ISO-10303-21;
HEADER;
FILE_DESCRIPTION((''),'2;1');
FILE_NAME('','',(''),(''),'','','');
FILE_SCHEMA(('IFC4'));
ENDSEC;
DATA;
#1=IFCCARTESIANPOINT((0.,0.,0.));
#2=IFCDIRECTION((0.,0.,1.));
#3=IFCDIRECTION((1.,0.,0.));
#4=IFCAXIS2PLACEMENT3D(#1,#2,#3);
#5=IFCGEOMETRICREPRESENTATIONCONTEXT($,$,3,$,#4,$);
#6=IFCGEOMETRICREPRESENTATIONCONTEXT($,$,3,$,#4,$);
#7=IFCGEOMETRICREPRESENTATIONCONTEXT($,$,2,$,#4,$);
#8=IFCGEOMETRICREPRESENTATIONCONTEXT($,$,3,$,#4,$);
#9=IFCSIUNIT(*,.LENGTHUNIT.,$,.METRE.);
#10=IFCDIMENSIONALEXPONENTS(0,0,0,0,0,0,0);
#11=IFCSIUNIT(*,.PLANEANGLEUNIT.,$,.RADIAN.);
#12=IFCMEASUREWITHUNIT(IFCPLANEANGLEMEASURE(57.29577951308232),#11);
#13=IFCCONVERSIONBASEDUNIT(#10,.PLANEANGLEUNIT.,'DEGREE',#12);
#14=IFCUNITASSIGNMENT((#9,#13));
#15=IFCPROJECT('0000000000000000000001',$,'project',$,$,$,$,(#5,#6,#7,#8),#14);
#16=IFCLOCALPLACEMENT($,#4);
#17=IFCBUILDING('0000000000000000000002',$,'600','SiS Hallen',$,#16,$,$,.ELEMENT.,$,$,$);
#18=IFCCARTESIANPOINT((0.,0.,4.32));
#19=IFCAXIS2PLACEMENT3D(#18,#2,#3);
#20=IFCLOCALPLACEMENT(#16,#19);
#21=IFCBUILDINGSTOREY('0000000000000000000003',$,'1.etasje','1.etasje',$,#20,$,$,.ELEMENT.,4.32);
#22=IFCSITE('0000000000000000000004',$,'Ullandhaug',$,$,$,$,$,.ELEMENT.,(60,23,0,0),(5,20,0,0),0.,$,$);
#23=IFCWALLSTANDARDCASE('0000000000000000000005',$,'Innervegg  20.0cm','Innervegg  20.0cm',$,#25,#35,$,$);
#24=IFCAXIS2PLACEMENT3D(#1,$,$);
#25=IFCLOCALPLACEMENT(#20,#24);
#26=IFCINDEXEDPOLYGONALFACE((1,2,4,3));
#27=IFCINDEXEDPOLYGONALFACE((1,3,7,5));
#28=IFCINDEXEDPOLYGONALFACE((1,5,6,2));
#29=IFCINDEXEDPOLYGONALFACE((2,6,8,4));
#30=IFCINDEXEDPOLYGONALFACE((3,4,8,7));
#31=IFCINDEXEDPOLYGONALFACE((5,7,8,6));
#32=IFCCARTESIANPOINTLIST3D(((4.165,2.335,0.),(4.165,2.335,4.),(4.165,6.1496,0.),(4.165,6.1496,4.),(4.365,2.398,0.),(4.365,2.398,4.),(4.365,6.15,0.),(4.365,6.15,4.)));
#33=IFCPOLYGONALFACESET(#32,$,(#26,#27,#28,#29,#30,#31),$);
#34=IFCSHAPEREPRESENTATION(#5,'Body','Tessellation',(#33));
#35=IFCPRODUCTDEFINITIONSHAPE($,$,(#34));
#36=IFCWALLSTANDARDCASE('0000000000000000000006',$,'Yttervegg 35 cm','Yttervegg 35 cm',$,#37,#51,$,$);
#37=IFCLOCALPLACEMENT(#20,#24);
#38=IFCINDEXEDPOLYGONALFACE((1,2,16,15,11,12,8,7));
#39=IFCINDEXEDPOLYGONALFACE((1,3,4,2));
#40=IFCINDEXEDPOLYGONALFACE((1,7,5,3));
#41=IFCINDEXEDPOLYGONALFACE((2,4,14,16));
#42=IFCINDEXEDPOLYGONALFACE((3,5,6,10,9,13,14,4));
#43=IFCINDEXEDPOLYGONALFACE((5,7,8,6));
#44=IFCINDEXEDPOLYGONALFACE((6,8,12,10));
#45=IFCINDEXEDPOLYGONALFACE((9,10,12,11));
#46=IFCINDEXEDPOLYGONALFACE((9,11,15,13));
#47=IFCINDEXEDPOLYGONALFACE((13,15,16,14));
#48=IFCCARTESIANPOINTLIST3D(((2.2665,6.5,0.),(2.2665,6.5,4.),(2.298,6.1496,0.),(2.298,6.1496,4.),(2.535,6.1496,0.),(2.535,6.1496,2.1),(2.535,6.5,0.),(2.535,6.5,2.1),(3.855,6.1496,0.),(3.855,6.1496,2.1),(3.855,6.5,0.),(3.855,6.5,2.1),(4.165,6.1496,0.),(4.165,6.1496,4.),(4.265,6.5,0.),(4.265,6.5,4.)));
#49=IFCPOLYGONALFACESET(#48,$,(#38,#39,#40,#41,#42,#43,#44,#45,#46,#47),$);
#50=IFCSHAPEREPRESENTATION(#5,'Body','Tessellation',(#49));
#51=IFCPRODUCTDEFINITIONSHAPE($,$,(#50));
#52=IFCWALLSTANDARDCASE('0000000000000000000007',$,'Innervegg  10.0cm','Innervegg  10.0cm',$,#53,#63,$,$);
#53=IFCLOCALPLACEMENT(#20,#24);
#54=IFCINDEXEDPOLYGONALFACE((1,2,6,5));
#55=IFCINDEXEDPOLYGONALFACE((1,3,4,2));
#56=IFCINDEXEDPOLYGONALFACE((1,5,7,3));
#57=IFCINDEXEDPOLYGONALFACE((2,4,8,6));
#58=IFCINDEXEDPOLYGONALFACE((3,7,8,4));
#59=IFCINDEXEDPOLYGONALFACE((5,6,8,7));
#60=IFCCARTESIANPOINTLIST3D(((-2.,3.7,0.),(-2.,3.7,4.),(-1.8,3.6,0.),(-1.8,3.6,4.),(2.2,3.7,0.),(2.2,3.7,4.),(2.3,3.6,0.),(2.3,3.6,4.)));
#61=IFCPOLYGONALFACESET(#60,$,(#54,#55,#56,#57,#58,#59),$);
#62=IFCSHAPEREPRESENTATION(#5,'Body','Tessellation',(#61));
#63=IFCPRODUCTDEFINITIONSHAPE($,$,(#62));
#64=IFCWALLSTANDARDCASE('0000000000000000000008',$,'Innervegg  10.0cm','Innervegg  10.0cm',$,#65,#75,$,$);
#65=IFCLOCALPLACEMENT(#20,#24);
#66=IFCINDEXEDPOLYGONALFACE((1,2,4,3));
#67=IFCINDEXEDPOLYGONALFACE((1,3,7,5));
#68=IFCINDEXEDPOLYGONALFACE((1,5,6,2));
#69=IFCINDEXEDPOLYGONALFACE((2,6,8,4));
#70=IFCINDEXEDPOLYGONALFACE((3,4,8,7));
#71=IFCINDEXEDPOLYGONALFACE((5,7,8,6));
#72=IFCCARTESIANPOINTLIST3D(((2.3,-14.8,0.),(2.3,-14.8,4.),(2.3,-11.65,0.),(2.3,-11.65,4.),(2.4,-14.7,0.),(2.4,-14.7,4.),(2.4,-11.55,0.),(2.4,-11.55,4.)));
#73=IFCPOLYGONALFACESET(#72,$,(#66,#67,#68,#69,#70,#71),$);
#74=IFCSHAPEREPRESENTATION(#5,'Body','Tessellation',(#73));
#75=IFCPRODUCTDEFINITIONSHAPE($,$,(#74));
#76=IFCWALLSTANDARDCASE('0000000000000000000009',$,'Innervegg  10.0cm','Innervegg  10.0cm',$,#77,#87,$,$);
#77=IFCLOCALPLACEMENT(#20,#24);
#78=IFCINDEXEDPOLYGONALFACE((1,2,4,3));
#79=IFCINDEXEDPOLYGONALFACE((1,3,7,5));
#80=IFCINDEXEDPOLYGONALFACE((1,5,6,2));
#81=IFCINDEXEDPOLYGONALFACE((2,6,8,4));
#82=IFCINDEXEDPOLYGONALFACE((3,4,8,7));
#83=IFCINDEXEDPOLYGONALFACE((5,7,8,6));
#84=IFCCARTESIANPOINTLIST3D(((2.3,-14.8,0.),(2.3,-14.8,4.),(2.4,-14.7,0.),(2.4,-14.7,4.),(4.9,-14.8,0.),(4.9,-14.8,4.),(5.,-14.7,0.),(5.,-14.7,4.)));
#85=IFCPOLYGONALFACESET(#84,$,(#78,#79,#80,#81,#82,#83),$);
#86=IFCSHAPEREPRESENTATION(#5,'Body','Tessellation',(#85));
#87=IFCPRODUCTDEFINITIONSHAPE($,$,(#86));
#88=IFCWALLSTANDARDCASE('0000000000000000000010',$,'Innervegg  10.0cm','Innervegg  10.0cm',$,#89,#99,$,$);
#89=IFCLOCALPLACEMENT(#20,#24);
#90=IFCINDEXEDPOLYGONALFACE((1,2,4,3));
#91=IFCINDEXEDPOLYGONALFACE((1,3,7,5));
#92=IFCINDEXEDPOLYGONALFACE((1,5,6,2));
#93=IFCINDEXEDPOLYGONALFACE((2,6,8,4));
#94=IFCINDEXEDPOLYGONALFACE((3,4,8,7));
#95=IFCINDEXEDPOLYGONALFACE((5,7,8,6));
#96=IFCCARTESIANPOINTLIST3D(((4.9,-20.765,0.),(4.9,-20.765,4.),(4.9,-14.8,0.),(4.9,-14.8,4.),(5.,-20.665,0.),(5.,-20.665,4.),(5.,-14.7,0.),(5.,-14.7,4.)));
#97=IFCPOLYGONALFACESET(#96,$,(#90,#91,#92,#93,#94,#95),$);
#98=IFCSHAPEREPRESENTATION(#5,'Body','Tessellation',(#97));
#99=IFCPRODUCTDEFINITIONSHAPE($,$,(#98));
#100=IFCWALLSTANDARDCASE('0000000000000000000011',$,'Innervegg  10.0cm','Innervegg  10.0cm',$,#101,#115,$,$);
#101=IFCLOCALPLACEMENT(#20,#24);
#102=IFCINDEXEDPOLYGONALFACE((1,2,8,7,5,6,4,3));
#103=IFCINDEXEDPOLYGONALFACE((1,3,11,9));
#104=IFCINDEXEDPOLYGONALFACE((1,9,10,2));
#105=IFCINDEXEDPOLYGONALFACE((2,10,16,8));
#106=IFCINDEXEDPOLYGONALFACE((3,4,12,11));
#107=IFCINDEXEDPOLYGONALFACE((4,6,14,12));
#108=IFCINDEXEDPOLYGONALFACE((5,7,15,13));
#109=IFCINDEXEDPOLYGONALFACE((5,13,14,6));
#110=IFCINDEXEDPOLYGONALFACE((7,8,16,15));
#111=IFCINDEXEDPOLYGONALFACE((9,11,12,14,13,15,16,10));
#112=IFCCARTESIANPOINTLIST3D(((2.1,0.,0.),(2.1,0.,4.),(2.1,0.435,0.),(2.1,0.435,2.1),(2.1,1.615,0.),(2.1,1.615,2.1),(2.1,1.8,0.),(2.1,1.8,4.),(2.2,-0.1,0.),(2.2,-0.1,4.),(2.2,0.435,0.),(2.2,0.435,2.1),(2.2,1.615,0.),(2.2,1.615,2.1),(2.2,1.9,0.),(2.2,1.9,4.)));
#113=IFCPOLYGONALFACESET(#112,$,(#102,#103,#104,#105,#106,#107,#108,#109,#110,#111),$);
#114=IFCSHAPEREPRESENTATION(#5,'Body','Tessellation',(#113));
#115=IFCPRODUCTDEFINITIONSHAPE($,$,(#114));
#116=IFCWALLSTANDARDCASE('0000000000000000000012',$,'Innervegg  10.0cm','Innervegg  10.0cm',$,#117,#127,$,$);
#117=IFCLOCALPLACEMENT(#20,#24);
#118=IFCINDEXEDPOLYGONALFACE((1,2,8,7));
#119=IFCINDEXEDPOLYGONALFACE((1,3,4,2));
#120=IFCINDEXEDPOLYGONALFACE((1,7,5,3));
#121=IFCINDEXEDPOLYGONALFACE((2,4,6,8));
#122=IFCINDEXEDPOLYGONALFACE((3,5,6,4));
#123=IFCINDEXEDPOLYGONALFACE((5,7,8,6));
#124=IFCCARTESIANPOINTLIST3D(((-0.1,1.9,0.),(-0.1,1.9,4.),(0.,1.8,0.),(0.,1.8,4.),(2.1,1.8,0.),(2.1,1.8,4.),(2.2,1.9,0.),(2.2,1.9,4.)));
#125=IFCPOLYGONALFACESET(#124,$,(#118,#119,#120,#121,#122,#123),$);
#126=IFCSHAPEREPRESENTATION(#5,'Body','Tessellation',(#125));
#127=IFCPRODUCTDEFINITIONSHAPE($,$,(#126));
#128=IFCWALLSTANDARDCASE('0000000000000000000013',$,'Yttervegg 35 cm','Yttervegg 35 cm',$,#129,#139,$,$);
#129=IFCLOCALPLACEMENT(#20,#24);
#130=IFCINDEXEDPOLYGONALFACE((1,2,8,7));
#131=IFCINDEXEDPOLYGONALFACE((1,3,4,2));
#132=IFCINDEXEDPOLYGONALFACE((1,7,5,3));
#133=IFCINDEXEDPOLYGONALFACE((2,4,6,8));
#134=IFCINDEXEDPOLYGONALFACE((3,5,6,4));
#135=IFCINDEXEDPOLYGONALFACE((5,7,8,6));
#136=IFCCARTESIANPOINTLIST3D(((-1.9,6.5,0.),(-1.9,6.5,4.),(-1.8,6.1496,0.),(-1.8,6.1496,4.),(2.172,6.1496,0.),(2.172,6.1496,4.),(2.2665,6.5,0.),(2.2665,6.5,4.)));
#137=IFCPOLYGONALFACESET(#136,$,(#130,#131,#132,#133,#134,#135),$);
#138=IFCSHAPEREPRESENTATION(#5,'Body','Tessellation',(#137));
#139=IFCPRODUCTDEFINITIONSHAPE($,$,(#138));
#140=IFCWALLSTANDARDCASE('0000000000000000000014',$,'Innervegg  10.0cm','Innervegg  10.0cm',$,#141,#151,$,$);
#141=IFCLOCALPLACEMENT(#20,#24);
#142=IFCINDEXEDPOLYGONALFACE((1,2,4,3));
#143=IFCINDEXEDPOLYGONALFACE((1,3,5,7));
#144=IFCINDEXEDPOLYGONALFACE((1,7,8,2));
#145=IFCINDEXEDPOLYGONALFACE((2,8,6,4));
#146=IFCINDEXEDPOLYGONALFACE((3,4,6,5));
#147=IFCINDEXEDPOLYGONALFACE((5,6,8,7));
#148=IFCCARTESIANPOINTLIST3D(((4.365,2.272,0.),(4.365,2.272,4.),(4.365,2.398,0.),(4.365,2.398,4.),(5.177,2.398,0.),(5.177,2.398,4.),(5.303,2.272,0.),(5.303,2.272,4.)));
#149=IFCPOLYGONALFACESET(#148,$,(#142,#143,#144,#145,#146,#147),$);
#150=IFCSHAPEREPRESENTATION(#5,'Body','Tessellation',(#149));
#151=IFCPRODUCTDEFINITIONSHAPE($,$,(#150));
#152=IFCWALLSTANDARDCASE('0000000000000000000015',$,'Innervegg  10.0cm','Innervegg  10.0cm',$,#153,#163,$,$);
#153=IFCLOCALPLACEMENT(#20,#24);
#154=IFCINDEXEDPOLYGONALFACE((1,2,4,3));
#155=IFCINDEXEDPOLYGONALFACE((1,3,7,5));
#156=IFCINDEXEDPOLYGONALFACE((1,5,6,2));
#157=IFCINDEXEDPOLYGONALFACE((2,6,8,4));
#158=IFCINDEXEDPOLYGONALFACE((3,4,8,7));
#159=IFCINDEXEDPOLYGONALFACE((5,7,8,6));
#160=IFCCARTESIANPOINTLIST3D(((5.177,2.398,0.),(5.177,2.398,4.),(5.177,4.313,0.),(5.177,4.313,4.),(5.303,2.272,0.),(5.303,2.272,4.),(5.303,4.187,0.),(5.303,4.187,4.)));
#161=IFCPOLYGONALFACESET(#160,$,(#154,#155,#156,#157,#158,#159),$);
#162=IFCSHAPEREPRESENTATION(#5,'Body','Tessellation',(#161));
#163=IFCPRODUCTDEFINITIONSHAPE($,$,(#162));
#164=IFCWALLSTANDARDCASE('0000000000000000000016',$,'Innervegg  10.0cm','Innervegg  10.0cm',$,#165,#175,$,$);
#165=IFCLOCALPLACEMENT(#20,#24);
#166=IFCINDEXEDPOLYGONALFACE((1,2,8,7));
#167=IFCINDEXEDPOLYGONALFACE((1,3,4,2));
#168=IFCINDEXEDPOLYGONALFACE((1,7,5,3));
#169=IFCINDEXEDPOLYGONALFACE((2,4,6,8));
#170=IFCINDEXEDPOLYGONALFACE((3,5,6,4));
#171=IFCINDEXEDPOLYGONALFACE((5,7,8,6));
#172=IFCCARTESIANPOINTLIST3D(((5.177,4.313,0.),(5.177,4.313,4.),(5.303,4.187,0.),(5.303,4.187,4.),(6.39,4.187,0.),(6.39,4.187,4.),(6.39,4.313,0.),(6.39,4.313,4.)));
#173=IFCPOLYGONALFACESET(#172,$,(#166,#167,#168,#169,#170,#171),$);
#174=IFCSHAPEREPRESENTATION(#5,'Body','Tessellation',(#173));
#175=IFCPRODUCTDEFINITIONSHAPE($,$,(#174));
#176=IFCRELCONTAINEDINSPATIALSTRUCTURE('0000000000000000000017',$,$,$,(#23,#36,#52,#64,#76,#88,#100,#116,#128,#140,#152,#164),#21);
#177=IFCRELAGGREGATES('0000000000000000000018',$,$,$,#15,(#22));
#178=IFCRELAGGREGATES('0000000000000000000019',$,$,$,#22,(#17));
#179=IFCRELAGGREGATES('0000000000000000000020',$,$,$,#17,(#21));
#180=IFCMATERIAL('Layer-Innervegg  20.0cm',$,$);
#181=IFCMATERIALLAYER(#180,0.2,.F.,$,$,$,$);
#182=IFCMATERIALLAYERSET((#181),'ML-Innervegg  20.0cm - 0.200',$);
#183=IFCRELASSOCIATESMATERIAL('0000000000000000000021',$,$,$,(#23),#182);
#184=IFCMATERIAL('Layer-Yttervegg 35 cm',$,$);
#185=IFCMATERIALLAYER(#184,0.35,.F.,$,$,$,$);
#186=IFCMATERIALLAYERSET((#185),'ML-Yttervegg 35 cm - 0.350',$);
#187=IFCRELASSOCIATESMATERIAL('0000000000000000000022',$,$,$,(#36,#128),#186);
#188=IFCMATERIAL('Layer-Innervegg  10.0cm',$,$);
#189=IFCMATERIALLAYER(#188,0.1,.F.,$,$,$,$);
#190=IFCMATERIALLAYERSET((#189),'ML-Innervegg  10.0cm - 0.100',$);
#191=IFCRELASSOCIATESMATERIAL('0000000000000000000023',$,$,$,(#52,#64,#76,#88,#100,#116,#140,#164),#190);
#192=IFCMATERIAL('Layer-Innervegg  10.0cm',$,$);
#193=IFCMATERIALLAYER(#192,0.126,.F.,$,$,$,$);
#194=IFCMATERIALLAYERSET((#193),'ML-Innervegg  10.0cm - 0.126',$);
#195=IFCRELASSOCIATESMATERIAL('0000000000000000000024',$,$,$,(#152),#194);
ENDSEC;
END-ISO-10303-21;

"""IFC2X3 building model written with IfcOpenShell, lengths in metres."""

from ifc_helpers import new_model, entity, si_unit, converted_unit, frame, origin_with_axes, place, context, project, spatial, polyline, outline, extrude, material, layer, layer_set, layer_usage, element, save


model = new_model("IFC2X3")

# Units and contexts
context_of_model_1 = context(None, 3, world=origin_with_axes())
context_of_model_2 = context(None, 3, world=origin_with_axes())
context_of_model_3 = context(None, 2, world=origin_with_axes())
context_of_model_4 = context(None, 3, world=origin_with_axes())
ifc_project = project(units=[si_unit("LENGTHUNIT", "METRE"), converted_unit("PLANEANGLEUNIT", "DEGREE", entity("IfcPlaneAngleMeasure", 57.29577951308232), si_unit("PLANEANGLEUNIT", "RADIAN"), dimensions=[0, 0, 0, 0, 0, 0, 0])], contexts=[context_of_model_1, context_of_model_2, context_of_model_3, context_of_model_4])

# Site, building, storey
site = spatial("IfcSite", under=ifc_project, Name="Ullandhaug", CompositionType="ELEMENT", RefLatitude=(60, 23, 0, 0), RefLongitude=(5, 20, 0, 0), RefElevation=0.0)
building_placement = place(None, origin_with_axes())
building = spatial("IfcBuilding", under=site, at=building_placement, Name="600", Description="SiS Hallen", CompositionType="ELEMENT")
storey_placement = place(building_placement, frame((0.0, 0.0, 4.32), z_axis=(0.0, 0.0, 1.0), x_axis=(1.0, 0.0, 0.0)))
storey = spatial("IfcBuildingStorey", under=building, at=storey_placement, Name="1.etasje", Description="1.etasje", CompositionType="ELEMENT", Elevation=4.32)

# Shared definitions
ifc_material_1 = material(Name="Layer-Innervegg  10.0cm")
ifc_layer_1 = layer(ifc_material_1, 0.126, ventilated=False)
ifc_layer_set_1 = layer_set([ifc_layer_1], Name="ML-Innervegg  10.0cm - 0.126")
ifc_layer_usage_1 = layer_usage(ifc_layer_set_1, "AXIS2", "POSITIVE", 0.0)

# Shared definitions
ifc_material_2 = material(Name="Layer-Innervegg  10.0cm")
ifc_layer_2 = layer(ifc_material_2, 0.1, ventilated=False)
ifc_layer_set_2 = layer_set([ifc_layer_2], Name="ML-Innervegg  10.0cm - 0.100")
ifc_layer_usage_2 = layer_usage(ifc_layer_set_2, "AXIS2", "POSITIVE", 0.0)

# Wall
ifc_material_3 = material(Name="Layer-Innervegg  20.0cm")
ifc_layer_3 = layer(ifc_material_3, 0.2, ventilated=False)
ifc_layer_set_3 = layer_set([ifc_layer_3], Name="ML-Innervegg  20.0cm - 0.200")
ifc_layer_usage_3 = layer_usage(ifc_layer_set_3, "AXIS2", "POSITIVE", 0.0)
wall_1_placement = place(storey_placement, frame((4.365, 2.398, 0.0), z_axis=(0.0, 0.0, 1.0), x_axis=(0.0, 1.0, 0.0)))
element("IfcWallStandardCase", 1, at=wall_1_placement, inside=storey, material=ifc_layer_usage_3, Name="Innervegg  20.0cm", Description="Innervegg  20.0cm", context=context_of_model_1, shape_type="SweptSolid", body=[
    extrude(outline(polyline([(0.0, 0.0), (3.752, 0.0), (3.7516, 0.2), (-0.063, 0.2), (0.0, 0.0)])), frame((0.0, 0.0, 0.0), z_axis=(0.0, 0.0, 1.0), x_axis=(1.0, 0.0, 0.0)), (0.0, 0.0, 1.0), 4.0),
])

# Wall, opening
ifc_material_4 = material(Name="Layer-Yttervegg 35 cm")
ifc_layer_4 = layer(ifc_material_4, 0.35, ventilated=False)
ifc_layer_set_4 = layer_set([ifc_layer_4], Name="ML-Yttervegg 35 cm - 0.350")
ifc_layer_usage_4 = layer_usage(ifc_layer_set_4, "AXIS2", "POSITIVE", 0.0)
wall_2_placement = place(storey_placement, frame((4.265, 6.5, 0.0), z_axis=(0.0, 0.0, 1.0), x_axis=(-1.0, 0.0, 0.0)))
wall_2 = element("IfcWallStandardCase", 2, at=wall_2_placement, inside=storey, material=ifc_layer_usage_4, Name="Yttervegg 35 cm", Description="Yttervegg 35 cm", context=context_of_model_1, shape_type="SweptSolid", body=[
    extrude(outline(polyline([(0.0, 0.0), (1.9985, 0.0), (1.967, 0.3504), (0.1, 0.3504), (0.0, 0.0)])), frame((0.0, 0.0, 0.0), z_axis=(0.0, 0.0, 1.0), x_axis=(1.0, 0.0, 0.0)), (0.0, 0.0, 1.0), 4.0),
])
opening_1_placement = place(wall_2_placement, frame((0.41, 0.3504, 0.0), z_axis=(0.0, 0.0, 1.0), x_axis=(1.0, 0.0, 0.0)))
element("IfcOpeningElement", 3, at=opening_1_placement, cuts=wall_2, context=context_of_model_1, shape_type="SweptSolid", body=[
    extrude(outline(polyline([(0.0, 0.0), (2.1, 0.0), (2.1, 1.32), (0.0, 1.32), (0.0, 0.0)])), frame((0.0, 0.0, 0.0), z_axis=(0.0, 1.0, 0.0), x_axis=(0.0, 0.0, 1.0)), (0.0, 0.0, -1.0), 0.3504),
])

# Walls
wall_3_placement = place(storey_placement, frame((2.2, 3.7, 0.0), z_axis=(0.0, 0.0, 1.0), x_axis=(-1.0, 0.0, 0.0)))
element("IfcWallStandardCase", 4, at=wall_3_placement, inside=storey, material=ifc_layer_usage_2, Name="Innervegg  10.0cm", Description="Innervegg  10.0cm", context=context_of_model_1, shape_type="SweptSolid", body=[
    extrude(outline(polyline([(0.0, 0.0), (4.2, 0.0), (4.0, 0.1), (-0.1, 0.1), (0.0, 0.0)])), frame((0.0, 0.0, 0.0), z_axis=(0.0, 0.0, 1.0), x_axis=(1.0, 0.0, 0.0)), (0.0, 0.0, 1.0), 4.0),
])
wall_4_placement = place(storey_placement, frame((2.3, -11.65, 0.0), z_axis=(0.0, 0.0, 1.0), x_axis=(0.0, -1.0, 0.0)))
element("IfcWallStandardCase", 5, at=wall_4_placement, inside=storey, material=ifc_layer_usage_2, Name="Innervegg  10.0cm", Description="Innervegg  10.0cm", context=context_of_model_1, shape_type="SweptSolid", body=[
    extrude(outline(polyline([(0.0, 0.0), (3.15, 0.0), (3.05, 0.1), (-0.1, 0.1), (0.0, 0.0)])), frame((0.0, 0.0, 0.0), z_axis=(0.0, 0.0, 1.0), x_axis=(1.0, 0.0, 0.0)), (0.0, 0.0, 1.0), 4.0),
])
wall_5_placement = place(storey_placement, frame((2.3, -14.8, 0.0), z_axis=(0.0, 0.0, 1.0), x_axis=(1.0, 0.0, 0.0)))
element("IfcWallStandardCase", 6, at=wall_5_placement, inside=storey, material=ifc_layer_usage_2, Name="Innervegg  10.0cm", Description="Innervegg  10.0cm", context=context_of_model_1, shape_type="SweptSolid", body=[
    extrude(outline(polyline([(0.0, 0.0), (2.6, 0.0), (2.7, 0.1), (0.1, 0.1), (0.0, 0.0)])), origin_with_axes(), (0.0, 0.0, 1.0), 4.0),
])
wall_6_placement = place(storey_placement, frame((4.9, -14.8, 0.0), z_axis=(0.0, 0.0, 1.0), x_axis=(0.0, -1.0, 0.0)))
element("IfcWallStandardCase", 7, at=wall_6_placement, inside=storey, material=ifc_layer_usage_2, Name="Innervegg  10.0cm", Description="Innervegg  10.0cm", context=context_of_model_1, shape_type="SweptSolid", body=[
    extrude(outline(polyline([(0.0, 0.0), (5.965, 0.0), (5.865, 0.1), (-0.1, 0.1), (0.0, 0.0)])), frame((0.0, 0.0, 0.0), z_axis=(0.0, 0.0, 1.0), x_axis=(1.0, 0.0, 0.0)), (0.0, 0.0, 1.0), 4.0),
])

# Wall, opening
wall_7_placement = place(storey_placement, frame((2.2, -0.1, 0.0), z_axis=(0.0, 0.0, 1.0), x_axis=(0.0, 1.0, 0.0)))
wall_7 = element("IfcWallStandardCase", 8, at=wall_7_placement, inside=storey, material=ifc_layer_usage_2, Name="Innervegg  10.0cm", Description="Innervegg  10.0cm", context=context_of_model_1, shape_type="SweptSolid", body=[
    extrude(outline(polyline([(0.0, 0.0), (2.0, 0.0), (1.9, 0.1), (0.1, 0.1), (0.0, 0.0)])), frame((0.0, 0.0, 0.0), z_axis=(0.0, 0.0, 1.0), x_axis=(1.0, 0.0, 0.0)), (0.0, 0.0, 1.0), 4.0),
])
opening_2_placement = place(wall_7_placement, frame((0.535, 0.1, 0.0), z_axis=(0.0, 0.0, 1.0), x_axis=(1.0, 0.0, 0.0)))
element("IfcOpeningElement", 9, at=opening_2_placement, cuts=wall_7, context=context_of_model_1, shape_type="SweptSolid", body=[
    extrude(outline(polyline([(0.0, 0.0), (2.1, 0.0), (2.1, 1.18), (0.0, 1.18), (0.0, 0.0)])), frame((0.0, 0.0, 0.0), z_axis=(0.0, 1.0, 0.0), x_axis=(0.0, 0.0, 1.0)), (0.0, 0.0, -1.0), 0.1),
])

# Walls
wall_8_placement = place(storey_placement, frame((2.2, 1.9, 0.0), z_axis=(0.0, 0.0, 1.0), x_axis=(-1.0, 0.0, 0.0)))
element("IfcWallStandardCase", 10, at=wall_8_placement, inside=storey, material=ifc_layer_usage_2, Name="Innervegg  10.0cm", Description="Innervegg  10.0cm", context=context_of_model_1, shape_type="SweptSolid", body=[
    extrude(outline(polyline([(0.0, 0.0), (2.3, 0.0), (2.2, 0.1), (0.1, 0.1), (0.0, 0.0)])), frame((0.0, 0.0, 0.0), z_axis=(0.0, 0.0, 1.0), x_axis=(1.0, 0.0, 0.0)), (0.0, 0.0, 1.0), 4.0),
])
wall_9_placement = place(storey_placement, frame((2.2665, 6.5, 0.0), z_axis=(0.0, 0.0, 1.0), x_axis=(-1.0, 0.0, 0.0)))
element("IfcWallStandardCase", 11, at=wall_9_placement, inside=storey, material=ifc_layer_usage_4, Name="Yttervegg 35 cm", Description="Yttervegg 35 cm", context=context_of_model_1, shape_type="SweptSolid", body=[
    extrude(outline(polyline([(0.0, 0.0), (4.1665, 0.0), (4.0665, 0.3504), (0.0945, 0.3504), (0.0, 0.0)])), frame((0.0, 0.0, 0.0), z_axis=(0.0, 0.0, 1.0), x_axis=(1.0, 0.0, 0.0)), (0.0, 0.0, 1.0), 4.0),
])
wall_10_placement = place(storey_placement, frame((4.365, 2.272, 0.0), z_axis=(0.0, 0.0, 1.0), x_axis=(1.0, 0.0, 0.0)))
element("IfcWallStandardCase", 12, at=wall_10_placement, inside=storey, material=ifc_layer_usage_2, Name="Innervegg  10.0cm", Description="Innervegg  10.0cm", context=context_of_model_1, shape_type="SweptSolid", body=[
    extrude(outline(polyline([(0.0, 0.0), (0.938, 0.0), (0.812, 0.126), (0.0, 0.126), (0.0, 0.0)])), origin_with_axes(), (0.0, 0.0, 1.0), 4.0),
])
wall_11_placement = place(storey_placement, frame((5.303, 2.272, 0.0), z_axis=(0.0, 0.0, 1.0), x_axis=(0.0, 1.0, 0.0)))
element("IfcWallStandardCase", 13, at=wall_11_placement, inside=storey, material=ifc_layer_usage_1, Name="Innervegg  10.0cm", Description="Innervegg  10.0cm", context=context_of_model_1, shape_type="SweptSolid", body=[
    extrude(outline(polyline([(0.0, 0.0), (1.915, 0.0), (2.041, 0.126), (0.126, 0.126), (0.0, 0.0)])), frame((0.0, 0.0, 0.0), z_axis=(0.0, 0.0, 1.0), x_axis=(1.0, 0.0, 0.0)), (0.0, 0.0, 1.0), 4.0),
])
wall_12_placement = place(storey_placement, frame((5.303, 4.187, 0.0), z_axis=(0.0, 0.0, 1.0), x_axis=(1.0, 0.0, 0.0)))
element("IfcWallStandardCase", 14, at=wall_12_placement, inside=storey, material=ifc_layer_usage_2, Name="Innervegg  10.0cm", Description="Innervegg  10.0cm", context=context_of_model_1, shape_type="SweptSolid", body=[
    extrude(outline(polyline([(0.0, 0.0), (1.087, 0.0), (1.087, 0.126), (-0.126, 0.126), (0.0, 0.0)])), origin_with_axes(), (0.0, 0.0, 1.0), 4.0),
])

save(model, "model.ifc")
